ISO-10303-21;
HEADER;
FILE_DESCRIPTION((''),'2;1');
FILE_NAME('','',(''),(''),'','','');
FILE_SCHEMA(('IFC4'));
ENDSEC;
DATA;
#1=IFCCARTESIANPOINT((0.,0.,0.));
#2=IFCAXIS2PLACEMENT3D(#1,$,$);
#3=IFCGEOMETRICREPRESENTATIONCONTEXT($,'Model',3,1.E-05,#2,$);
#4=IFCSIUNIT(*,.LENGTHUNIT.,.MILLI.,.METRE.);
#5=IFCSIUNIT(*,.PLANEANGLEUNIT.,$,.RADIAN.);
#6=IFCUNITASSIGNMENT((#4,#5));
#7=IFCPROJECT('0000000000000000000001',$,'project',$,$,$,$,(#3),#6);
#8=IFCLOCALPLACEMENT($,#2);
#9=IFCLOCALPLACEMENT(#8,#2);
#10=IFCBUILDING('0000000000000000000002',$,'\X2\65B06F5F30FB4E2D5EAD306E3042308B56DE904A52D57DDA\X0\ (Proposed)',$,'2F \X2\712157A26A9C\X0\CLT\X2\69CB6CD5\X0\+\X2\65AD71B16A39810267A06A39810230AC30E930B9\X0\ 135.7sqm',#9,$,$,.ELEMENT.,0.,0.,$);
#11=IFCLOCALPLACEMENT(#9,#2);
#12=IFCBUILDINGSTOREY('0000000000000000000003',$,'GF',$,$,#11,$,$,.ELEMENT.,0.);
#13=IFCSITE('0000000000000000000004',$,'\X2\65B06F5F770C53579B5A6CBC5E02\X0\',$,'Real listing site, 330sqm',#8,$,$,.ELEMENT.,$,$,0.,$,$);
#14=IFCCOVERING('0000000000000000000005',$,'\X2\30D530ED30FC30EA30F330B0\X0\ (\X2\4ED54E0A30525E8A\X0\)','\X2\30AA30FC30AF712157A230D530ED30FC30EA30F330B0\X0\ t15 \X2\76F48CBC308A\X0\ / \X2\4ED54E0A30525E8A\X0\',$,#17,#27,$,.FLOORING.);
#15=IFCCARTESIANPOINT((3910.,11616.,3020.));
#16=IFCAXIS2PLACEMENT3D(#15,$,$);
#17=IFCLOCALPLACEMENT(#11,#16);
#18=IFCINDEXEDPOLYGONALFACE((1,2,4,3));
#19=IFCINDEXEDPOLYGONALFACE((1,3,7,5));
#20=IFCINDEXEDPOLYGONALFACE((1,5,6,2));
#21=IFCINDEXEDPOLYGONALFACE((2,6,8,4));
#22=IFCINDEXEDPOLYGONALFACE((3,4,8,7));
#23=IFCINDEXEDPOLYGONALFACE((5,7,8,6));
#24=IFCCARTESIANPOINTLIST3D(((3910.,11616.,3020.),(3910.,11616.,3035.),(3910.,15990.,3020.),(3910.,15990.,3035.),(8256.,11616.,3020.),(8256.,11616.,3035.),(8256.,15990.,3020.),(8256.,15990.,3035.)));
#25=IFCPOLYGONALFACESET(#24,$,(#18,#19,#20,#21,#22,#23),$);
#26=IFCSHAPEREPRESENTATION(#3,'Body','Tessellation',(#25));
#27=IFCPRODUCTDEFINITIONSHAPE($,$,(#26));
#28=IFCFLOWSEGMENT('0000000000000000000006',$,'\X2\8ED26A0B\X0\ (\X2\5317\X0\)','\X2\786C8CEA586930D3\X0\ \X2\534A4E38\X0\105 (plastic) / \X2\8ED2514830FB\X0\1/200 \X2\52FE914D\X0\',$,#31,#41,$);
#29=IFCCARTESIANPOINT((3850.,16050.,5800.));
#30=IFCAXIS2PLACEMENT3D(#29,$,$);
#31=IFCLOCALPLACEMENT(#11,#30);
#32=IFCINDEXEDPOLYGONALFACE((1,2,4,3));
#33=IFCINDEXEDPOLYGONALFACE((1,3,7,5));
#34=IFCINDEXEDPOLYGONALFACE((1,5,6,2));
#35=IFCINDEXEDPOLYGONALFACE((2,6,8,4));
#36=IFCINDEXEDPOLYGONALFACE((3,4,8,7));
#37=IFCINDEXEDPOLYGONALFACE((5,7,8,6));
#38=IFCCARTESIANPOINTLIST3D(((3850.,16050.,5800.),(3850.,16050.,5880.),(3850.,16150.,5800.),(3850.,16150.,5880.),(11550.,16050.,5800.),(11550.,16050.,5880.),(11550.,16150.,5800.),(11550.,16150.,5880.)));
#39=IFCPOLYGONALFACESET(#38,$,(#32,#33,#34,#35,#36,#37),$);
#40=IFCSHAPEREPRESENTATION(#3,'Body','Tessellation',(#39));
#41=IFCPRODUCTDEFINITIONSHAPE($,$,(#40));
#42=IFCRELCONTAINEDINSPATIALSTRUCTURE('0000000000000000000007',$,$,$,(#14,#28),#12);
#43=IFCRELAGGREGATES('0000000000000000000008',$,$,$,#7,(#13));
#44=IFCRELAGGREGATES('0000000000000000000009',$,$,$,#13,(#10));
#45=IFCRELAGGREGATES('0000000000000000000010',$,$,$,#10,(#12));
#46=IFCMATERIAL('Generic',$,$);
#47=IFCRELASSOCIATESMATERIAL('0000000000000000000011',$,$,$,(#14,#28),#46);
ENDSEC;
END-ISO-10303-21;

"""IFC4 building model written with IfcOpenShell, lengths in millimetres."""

from ifc_helpers import new_model, si_unit, frame, frame_2d, origin, place, context, project, spatial, rectangle, extrude, material, element, save


model = new_model("IFC4")

# Units and contexts
model_context = context("Model", 3, precision=1e-05, world=origin())
ifc_project = project(units=[si_unit("LENGTHUNIT", "METRE", prefix="MILLI"), si_unit("PLANEANGLEUNIT", "RADIAN")], contexts=[model_context])

# Site, building, storey
site_placement = place(None, origin())
site = spatial("IfcSite", under=ifc_project, at=site_placement, Name="新潟県南魚沼市", ObjectType="Real listing site, 330sqm", CompositionType="ELEMENT", RefElevation=0.0)
building_placement = place(site_placement, origin())
building = spatial("IfcBuilding", under=site, at=building_placement, Name="新潟・中庭のある回遊動線 (Proposed)", ObjectType="2F 無垢檜CLT構法+断熱樹脂枠樹脂ガラス 135.7sqm", CompositionType="ELEMENT", ElevationOfRefHeight=0.0, ElevationOfTerrain=0.0)
storey_placement = place(building_placement, origin())
storey = spatial("IfcBuildingStorey", under=building, at=storey_placement, Name="GF", CompositionType="ELEMENT", Elevation=0.0)

# Covering
ifc_material_1 = material(Name="Generic")
covering_placement = place(storey_placement, frame((3910.0, 11616.0, 3020.0)))
element("IfcCovering", 1, at=covering_placement, inside=storey, material=ifc_material_1, Name="フローリング (仕上げ床)", Description="オーク無垢フローリング t15 直貼り / 仕上げ床", PredefinedType="FLOORING", context=model_context, shape_type="SweptSolid", body=[
    extrude(rectangle(XDim=4346.0, YDim=4374.0, at=frame_2d((2173.0, 2187.0))), frame((3910.0, 11616.0, 3020.0)), (0.0, 0.0, 1.0), 15.0),
])

# Flow segment
flow_segment_placement = place(storey_placement, frame((3850.0, 16050.0, 5800.0)))
element("IfcFlowSegment", 2, at=flow_segment_placement, inside=storey, material=ifc_material_1, Name="軒樋 (北)", Description="硬質塩ビ 半丸105 (plastic) / 軒先・1/200 勾配", context=model_context, shape_type="SweptSolid", body=[
    extrude(rectangle(XDim=7700.0, YDim=100.0, at=frame_2d((3850.0, 50.0))), frame((3850.0, 16050.0, 5800.0)), (0.0, 0.0, 1.0), 80.0),
])

save(model, "model.ifc")
